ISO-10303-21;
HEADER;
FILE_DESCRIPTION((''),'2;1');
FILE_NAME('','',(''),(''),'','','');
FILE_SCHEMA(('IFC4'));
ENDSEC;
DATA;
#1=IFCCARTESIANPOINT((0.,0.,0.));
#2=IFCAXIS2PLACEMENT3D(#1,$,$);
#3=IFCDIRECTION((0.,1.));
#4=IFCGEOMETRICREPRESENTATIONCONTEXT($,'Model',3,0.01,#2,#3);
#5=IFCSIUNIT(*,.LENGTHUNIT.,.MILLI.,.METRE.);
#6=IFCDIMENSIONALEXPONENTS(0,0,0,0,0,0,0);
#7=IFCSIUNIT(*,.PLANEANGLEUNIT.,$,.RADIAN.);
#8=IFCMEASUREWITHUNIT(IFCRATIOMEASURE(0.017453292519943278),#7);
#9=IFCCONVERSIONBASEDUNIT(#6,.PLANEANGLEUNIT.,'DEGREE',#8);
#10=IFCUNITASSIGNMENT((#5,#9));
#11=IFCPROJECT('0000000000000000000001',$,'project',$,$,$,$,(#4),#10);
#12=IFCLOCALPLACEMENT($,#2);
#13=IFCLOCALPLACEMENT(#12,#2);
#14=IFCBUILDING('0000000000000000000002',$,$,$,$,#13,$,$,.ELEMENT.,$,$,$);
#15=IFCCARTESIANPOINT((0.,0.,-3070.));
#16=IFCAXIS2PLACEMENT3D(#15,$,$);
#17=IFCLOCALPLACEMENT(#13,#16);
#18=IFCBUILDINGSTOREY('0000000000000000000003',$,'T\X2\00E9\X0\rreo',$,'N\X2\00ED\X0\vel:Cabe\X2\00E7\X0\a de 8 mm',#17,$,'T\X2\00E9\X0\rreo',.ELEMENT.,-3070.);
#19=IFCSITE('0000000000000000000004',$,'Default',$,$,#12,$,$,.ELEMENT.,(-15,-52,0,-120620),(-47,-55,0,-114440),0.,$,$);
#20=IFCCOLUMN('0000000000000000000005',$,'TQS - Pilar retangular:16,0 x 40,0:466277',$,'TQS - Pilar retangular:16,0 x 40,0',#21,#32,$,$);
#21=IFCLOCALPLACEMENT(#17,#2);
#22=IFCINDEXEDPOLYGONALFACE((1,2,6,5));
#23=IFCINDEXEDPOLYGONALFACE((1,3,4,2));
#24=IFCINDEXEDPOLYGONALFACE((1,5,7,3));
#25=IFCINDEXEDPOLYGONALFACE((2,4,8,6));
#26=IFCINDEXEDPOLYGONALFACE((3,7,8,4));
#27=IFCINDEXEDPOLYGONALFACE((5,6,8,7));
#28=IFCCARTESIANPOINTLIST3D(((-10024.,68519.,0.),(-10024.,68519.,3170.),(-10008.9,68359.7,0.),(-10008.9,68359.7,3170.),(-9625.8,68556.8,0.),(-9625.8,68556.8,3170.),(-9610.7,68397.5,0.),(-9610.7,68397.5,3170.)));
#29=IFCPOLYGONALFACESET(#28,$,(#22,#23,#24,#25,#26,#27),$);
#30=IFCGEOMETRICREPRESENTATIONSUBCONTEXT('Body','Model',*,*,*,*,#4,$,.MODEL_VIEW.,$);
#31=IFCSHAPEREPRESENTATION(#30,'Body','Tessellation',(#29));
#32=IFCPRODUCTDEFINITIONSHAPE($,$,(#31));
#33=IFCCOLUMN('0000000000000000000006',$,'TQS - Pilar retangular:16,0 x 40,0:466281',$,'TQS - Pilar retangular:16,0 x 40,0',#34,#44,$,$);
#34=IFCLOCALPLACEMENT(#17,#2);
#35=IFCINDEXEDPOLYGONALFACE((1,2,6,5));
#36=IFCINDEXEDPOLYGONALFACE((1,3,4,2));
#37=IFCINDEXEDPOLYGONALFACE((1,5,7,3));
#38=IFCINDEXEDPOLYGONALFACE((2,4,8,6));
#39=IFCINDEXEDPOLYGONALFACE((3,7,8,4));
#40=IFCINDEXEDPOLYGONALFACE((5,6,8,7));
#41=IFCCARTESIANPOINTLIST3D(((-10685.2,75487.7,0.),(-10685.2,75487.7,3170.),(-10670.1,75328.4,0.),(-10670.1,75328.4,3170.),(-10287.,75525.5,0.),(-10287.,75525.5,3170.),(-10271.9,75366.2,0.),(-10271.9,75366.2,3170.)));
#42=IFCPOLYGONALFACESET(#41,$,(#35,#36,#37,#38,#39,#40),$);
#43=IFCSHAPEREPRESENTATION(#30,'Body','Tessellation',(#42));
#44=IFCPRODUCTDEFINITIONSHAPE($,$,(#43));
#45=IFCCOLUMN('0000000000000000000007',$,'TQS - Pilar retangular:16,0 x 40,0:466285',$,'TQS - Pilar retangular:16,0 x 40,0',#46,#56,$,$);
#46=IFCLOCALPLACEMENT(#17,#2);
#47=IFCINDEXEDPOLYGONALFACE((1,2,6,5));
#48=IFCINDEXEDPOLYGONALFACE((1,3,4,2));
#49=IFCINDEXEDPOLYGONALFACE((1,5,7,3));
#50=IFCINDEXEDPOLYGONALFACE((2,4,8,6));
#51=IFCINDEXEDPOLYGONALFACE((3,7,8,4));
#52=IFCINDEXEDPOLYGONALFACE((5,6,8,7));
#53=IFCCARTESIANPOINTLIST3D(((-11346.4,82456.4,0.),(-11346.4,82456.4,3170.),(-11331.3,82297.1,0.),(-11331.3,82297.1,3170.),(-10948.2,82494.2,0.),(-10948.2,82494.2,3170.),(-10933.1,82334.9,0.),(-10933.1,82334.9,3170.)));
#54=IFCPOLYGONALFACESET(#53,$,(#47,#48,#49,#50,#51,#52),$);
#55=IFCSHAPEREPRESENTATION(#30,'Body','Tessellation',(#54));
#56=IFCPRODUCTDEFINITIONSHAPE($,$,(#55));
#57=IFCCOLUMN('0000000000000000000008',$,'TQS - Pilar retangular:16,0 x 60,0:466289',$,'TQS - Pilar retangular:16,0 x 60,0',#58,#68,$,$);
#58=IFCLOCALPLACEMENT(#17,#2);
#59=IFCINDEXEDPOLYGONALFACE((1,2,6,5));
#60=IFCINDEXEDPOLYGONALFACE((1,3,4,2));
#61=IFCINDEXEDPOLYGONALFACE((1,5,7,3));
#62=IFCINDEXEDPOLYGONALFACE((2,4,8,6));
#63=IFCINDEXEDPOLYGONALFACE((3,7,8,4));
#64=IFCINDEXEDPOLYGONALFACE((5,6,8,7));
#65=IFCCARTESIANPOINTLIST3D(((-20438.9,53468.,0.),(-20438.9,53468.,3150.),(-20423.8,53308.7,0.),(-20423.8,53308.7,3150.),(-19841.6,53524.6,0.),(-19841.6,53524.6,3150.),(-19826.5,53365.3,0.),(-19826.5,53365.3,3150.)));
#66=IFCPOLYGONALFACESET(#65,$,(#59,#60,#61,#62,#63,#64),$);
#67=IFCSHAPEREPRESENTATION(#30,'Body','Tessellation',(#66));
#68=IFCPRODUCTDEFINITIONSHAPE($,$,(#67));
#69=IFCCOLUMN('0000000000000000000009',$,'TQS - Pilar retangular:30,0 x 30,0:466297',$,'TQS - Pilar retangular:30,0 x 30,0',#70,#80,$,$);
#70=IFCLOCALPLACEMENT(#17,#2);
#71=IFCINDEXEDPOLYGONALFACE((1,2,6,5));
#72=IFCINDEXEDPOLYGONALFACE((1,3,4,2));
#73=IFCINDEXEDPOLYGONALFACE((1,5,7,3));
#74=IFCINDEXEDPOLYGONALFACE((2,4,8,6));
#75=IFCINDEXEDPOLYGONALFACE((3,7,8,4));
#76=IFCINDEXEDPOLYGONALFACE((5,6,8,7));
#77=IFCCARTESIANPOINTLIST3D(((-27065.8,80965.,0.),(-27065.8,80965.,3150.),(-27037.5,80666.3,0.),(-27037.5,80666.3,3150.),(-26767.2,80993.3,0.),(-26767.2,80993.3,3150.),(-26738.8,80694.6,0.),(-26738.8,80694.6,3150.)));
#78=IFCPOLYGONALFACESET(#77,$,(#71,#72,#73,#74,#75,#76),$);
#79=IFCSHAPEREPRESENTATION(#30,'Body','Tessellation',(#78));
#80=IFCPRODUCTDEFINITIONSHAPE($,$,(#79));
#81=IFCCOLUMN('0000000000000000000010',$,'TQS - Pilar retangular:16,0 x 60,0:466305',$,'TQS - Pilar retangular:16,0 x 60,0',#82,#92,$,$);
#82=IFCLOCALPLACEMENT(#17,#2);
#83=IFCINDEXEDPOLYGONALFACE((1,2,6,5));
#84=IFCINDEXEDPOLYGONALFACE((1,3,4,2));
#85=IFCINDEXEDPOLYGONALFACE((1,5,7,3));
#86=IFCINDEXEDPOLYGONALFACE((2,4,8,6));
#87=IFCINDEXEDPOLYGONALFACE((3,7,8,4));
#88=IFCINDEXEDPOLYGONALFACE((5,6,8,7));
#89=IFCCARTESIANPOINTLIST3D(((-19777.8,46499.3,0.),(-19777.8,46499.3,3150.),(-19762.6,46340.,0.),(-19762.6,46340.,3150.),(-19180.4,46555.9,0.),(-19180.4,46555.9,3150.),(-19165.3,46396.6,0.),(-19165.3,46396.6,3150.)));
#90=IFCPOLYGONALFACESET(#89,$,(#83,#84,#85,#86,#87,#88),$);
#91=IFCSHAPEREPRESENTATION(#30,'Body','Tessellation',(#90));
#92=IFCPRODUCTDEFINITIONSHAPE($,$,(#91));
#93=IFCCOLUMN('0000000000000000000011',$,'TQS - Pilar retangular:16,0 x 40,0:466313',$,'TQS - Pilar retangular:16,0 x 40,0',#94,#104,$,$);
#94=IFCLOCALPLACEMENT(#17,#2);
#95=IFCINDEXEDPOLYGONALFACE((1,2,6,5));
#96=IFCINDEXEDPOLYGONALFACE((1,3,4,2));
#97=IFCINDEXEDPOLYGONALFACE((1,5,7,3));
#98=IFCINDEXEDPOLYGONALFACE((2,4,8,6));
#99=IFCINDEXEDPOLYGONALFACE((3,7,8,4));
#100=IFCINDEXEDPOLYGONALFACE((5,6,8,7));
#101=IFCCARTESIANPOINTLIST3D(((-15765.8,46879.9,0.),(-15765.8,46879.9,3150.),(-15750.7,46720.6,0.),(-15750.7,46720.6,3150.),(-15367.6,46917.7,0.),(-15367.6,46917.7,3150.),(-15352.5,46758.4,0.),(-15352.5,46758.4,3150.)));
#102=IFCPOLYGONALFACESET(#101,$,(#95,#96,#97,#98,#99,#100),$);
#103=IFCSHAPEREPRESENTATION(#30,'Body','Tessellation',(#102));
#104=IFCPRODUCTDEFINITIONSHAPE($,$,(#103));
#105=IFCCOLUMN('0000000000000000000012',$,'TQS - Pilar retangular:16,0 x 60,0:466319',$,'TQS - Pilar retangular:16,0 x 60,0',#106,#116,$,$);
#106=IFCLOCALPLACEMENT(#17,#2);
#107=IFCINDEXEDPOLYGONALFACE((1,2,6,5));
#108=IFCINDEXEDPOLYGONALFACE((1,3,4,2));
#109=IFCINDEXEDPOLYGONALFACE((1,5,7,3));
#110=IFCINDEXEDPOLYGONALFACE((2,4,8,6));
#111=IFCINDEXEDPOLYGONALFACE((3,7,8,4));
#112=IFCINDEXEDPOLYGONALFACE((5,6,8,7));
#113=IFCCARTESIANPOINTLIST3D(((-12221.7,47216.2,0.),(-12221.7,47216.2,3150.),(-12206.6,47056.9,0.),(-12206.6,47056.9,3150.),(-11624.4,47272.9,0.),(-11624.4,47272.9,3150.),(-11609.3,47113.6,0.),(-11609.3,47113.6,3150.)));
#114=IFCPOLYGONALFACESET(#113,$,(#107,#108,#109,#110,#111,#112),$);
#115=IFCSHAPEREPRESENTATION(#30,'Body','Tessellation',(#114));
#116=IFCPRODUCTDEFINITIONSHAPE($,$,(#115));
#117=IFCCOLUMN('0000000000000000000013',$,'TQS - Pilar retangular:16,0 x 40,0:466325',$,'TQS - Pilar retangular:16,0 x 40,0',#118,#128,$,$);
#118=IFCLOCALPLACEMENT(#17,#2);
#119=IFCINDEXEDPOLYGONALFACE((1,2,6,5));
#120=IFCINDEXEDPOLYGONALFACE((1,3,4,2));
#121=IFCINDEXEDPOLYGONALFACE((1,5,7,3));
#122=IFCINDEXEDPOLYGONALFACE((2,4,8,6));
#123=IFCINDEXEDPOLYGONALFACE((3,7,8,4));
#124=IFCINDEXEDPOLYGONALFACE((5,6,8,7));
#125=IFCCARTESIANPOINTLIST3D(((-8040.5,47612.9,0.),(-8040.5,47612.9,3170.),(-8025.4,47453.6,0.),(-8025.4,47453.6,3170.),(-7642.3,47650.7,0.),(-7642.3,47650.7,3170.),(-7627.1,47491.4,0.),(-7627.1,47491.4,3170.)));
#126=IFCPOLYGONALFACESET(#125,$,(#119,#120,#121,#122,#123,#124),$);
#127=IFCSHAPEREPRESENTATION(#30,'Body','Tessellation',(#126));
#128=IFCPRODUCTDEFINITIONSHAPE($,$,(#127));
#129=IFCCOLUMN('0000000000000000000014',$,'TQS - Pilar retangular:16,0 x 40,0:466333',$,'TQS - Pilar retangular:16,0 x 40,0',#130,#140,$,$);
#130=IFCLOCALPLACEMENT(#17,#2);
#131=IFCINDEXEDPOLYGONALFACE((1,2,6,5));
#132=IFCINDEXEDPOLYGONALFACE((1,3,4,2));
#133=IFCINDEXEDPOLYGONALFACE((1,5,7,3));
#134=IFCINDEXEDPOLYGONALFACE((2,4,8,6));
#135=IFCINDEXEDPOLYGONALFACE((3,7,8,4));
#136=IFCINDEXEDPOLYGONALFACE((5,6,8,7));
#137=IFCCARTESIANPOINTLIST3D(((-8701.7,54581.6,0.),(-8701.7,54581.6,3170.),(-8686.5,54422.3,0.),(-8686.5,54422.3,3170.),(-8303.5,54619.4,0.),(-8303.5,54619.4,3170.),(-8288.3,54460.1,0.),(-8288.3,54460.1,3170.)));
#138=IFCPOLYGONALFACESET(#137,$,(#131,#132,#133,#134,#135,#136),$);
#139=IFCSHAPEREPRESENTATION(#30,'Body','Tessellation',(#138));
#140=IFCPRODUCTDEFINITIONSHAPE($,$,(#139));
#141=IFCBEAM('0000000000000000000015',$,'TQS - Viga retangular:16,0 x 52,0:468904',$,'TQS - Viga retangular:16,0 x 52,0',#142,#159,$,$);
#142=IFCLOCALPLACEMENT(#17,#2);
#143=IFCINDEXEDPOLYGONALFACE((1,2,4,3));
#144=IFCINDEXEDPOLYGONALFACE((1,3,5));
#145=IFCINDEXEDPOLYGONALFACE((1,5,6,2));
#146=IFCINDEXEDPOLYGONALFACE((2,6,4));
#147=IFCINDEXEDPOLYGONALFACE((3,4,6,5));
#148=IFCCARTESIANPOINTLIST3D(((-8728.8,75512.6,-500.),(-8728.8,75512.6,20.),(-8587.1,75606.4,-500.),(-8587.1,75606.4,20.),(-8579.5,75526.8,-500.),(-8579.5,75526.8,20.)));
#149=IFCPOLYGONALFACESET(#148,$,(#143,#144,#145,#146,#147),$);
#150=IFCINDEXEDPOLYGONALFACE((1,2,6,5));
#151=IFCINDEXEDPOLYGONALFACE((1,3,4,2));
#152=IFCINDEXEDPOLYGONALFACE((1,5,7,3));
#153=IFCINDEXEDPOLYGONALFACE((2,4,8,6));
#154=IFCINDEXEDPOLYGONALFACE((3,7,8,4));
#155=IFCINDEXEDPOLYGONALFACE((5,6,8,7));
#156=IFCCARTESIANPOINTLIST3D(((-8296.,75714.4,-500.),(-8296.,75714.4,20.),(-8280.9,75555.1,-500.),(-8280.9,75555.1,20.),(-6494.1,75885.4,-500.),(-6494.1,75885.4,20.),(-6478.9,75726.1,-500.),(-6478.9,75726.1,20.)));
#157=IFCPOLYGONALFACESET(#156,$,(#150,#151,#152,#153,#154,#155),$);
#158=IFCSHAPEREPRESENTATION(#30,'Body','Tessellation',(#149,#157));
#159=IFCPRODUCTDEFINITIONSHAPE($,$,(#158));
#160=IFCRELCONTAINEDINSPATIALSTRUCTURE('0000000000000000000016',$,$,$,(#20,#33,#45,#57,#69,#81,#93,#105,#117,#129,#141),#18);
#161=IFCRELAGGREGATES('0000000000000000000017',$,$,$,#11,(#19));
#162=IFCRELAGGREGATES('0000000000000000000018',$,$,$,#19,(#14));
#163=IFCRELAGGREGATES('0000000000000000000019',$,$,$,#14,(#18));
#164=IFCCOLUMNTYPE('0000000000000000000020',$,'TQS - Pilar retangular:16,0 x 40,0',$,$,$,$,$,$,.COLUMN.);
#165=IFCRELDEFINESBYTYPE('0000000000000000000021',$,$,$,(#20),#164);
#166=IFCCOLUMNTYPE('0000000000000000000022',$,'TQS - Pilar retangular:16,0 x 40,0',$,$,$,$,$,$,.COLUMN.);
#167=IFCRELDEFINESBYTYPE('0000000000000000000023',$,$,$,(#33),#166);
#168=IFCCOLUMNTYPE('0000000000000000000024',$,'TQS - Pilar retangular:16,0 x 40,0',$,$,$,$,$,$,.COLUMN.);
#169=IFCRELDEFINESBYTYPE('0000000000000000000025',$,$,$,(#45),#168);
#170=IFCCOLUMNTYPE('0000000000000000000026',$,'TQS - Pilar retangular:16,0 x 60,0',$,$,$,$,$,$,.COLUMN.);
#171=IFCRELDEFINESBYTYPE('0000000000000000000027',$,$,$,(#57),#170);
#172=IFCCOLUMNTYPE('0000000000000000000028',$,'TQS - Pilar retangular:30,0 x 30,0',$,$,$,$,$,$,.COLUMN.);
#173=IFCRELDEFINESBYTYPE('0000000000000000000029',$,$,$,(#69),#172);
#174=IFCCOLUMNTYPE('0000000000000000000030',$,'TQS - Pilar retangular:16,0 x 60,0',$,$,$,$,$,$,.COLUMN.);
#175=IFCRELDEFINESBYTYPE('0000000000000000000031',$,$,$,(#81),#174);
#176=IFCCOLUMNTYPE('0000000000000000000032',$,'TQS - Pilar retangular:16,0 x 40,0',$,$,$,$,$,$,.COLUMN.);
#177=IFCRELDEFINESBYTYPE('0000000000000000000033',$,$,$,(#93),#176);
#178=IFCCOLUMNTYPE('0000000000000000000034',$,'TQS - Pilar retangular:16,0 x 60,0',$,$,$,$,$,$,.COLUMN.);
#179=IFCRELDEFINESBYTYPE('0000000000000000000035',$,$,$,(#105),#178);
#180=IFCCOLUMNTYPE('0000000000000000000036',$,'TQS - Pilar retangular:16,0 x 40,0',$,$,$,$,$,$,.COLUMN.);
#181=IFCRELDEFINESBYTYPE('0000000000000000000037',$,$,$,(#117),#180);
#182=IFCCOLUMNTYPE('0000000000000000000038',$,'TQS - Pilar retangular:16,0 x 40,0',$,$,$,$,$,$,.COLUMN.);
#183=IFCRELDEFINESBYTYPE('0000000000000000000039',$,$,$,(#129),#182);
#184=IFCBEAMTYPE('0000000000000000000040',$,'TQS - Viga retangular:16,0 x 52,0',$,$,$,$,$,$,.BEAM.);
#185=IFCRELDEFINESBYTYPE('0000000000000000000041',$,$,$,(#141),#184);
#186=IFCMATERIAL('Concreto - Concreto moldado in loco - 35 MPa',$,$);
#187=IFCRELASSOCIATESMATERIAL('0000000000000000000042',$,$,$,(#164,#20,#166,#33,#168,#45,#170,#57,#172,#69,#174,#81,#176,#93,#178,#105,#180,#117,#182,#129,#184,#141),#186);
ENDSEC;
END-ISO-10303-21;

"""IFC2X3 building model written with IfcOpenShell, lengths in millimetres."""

from ifc_helpers import new_model, entity, si_unit, converted_unit, direction, frame, frame_2d, origin, origin_2d_with_axis, place, context, subcontext, project, spatial, rectangle, extrude, clip, halfspace, source, transform, mapped, material, type_object, type_shapes, element, save


model = new_model("IFC2X3")

# Units and contexts
model_context = context("Model", 3, precision=0.01, world=origin(), true_north=direction((0.0, 1.0)))
body_context = subcontext(model_context, "Body", "Model", "MODEL_VIEW")
ifc_project = project(units=[si_unit("LENGTHUNIT", "METRE", prefix="MILLI"), converted_unit("PLANEANGLEUNIT", "DEGREE", entity("IfcRatioMeasure", 0.017453292519943278), si_unit("PLANEANGLEUNIT", "RADIAN"), dimensions=[0, 0, 0, 0, 0, 0, 0])], contexts=[model_context])

# Site, building, storey
site_placement = place(None, origin())
site = spatial("IfcSite", under=ifc_project, at=site_placement, Name="Default", CompositionType="ELEMENT", RefLatitude=(-15, -52, 0, -120620), RefLongitude=(-47, -55, 0, -114440), RefElevation=0.0)
building_placement = place(site_placement, origin())
building = spatial("IfcBuilding", under=site, at=building_placement, CompositionType="ELEMENT")
storey_placement = place(building_placement, frame((0.0, 0.0, -3070.0)))
storey = spatial("IfcBuildingStorey", under=building, at=storey_placement, Name="Térreo", ObjectType="Nível:Cabeça de 8 mm", LongName="Térreo", CompositionType="ELEMENT", Elevation=-3070.0)

# Columns
ifc_material = material(Name="Concreto - Concreto moldado in loco - 35 MPa")
column_type_1 = type_object("IfcColumnType", Name="TQS - Pilar retangular:16,0 x 40,0", PredefinedType="COLUMN", material=ifc_material)
shared_shape_1 = source(origin(), body_context, "Body", "SweptSolid", [
    extrude(rectangle(XDim=400.0, YDim=160.0, at=frame_2d((0.0, 0.0), x_axis=(1.0, 0.0))), frame((-9817.4, 68458.3, -3070.0), z_axis=(0.0, 0.0, 1.0), x_axis=(-0.995529, -0.094456, 0.0)), (0.0, 0.0, 1.0), 3170.0),
])
type_shapes(column_type_1, [shared_shape_1])
column_1_placement = place(storey_placement, frame((0.0, 0.0, 3070.0)))
element("IfcColumn", 1, at=column_1_placement, inside=storey, type_object=column_type_1, material=ifc_material, Name="TQS - Pilar retangular:16,0 x 40,0:466277", ObjectType="TQS - Pilar retangular:16,0 x 40,0", context=body_context, shape_type="MappedRepresentation", body=[
    mapped(shared_shape_1, transform((0.0, 0.0, 0.0), scale=1.0)),
])
column_type_2 = type_object("IfcColumnType", Name="TQS - Pilar retangular:16,0 x 40,0", PredefinedType="COLUMN", material=ifc_material)
shared_shape_2 = source(origin(), body_context, "Body", "SweptSolid", [
    extrude(rectangle(XDim=400.0, YDim=160.0, at=origin_2d_with_axis()), frame((-10478.6, 75427.0, -3070.0), z_axis=(0.0, 0.0, 1.0), x_axis=(-0.995529, -0.094456, 0.0)), (0.0, 0.0, 1.0), 3170.0),
])
type_shapes(column_type_2, [shared_shape_2])
column_2_placement = place(storey_placement, frame((0.0, 0.0, 3070.0)))
element("IfcColumn", 2, at=column_2_placement, inside=storey, type_object=column_type_2, material=ifc_material, Name="TQS - Pilar retangular:16,0 x 40,0:466281", ObjectType="TQS - Pilar retangular:16,0 x 40,0", context=body_context, shape_type="MappedRepresentation", body=[
    mapped(shared_shape_2, transform((0.0, 0.0, 0.0), scale=1.0)),
])
column_type_3 = type_object("IfcColumnType", Name="TQS - Pilar retangular:16,0 x 40,0", PredefinedType="COLUMN", material=ifc_material)
shared_shape_3 = source(origin(), body_context, "Body", "SweptSolid", [
    extrude(rectangle(XDim=400.0, YDim=160.0, at=origin_2d_with_axis()), frame((-11139.8, 82395.7, -3070.0), z_axis=(0.0, 0.0, 1.0), x_axis=(-0.995529, -0.094456, 0.0)), (0.0, 0.0, 1.0), 3170.0),
])
type_shapes(column_type_3, [shared_shape_3])
column_3_placement = place(storey_placement, frame((0.0, 0.0, 3070.0)))
element("IfcColumn", 3, at=column_3_placement, inside=storey, type_object=column_type_3, material=ifc_material, Name="TQS - Pilar retangular:16,0 x 40,0:466285", ObjectType="TQS - Pilar retangular:16,0 x 40,0", context=body_context, shape_type="MappedRepresentation", body=[
    mapped(shared_shape_3, transform((0.0, 0.0, 0.0), scale=1.0)),
])
column_type_4 = type_object("IfcColumnType", Name="TQS - Pilar retangular:16,0 x 60,0", PredefinedType="COLUMN", material=ifc_material)
shared_shape_4 = source(origin(), body_context, "Body", "SweptSolid", [
    extrude(rectangle(XDim=600.0, YDim=160.0, at=origin_2d_with_axis()), frame((-20132.7, 53416.7, -3070.0), z_axis=(0.0, 0.0, 1.0), x_axis=(-0.995529, -0.094456, 0.0)), (0.0, 0.0, 1.0), 3150.0),
])
type_shapes(column_type_4, [shared_shape_4])
column_4_placement = place(storey_placement, frame((0.0, 0.0, 3070.0)))
element("IfcColumn", 4, at=column_4_placement, inside=storey, type_object=column_type_4, material=ifc_material, Name="TQS - Pilar retangular:16,0 x 60,0:466289", ObjectType="TQS - Pilar retangular:16,0 x 60,0", context=body_context, shape_type="MappedRepresentation", body=[
    mapped(shared_shape_4, transform((0.0, 0.0, 0.0), scale=1.0)),
])
column_type_5 = type_object("IfcColumnType", Name="TQS - Pilar retangular:30,0 x 30,0", PredefinedType="COLUMN", material=ifc_material)
shared_shape_5 = source(origin(), body_context, "Body", "SweptSolid", [
    extrude(rectangle(XDim=300.0, YDim=300.0, at=origin_2d_with_axis()), frame((-26902.3, 80829.8, -3070.0), z_axis=(0.0, 0.0, 1.0), x_axis=(-0.995529, -0.094456, 0.0)), (0.0, 0.0, 1.0), 3150.0),
])
type_shapes(column_type_5, [shared_shape_5])
column_5_placement = place(storey_placement, frame((0.0, 0.0, 3070.0)))
element("IfcColumn", 5, at=column_5_placement, inside=storey, type_object=column_type_5, material=ifc_material, Name="TQS - Pilar retangular:30,0 x 30,0:466297", ObjectType="TQS - Pilar retangular:30,0 x 30,0", context=body_context, shape_type="MappedRepresentation", body=[
    mapped(shared_shape_5, transform((0.0, 0.0, 0.0), scale=1.0)),
])
column_type_6 = type_object("IfcColumnType", Name="TQS - Pilar retangular:16,0 x 60,0", PredefinedType="COLUMN", material=ifc_material)
shared_shape_6 = source(origin(), body_context, "Body", "SweptSolid", [
    extrude(rectangle(XDim=600.0, YDim=160.0, at=origin_2d_with_axis()), frame((-19471.5, 46448.0, -3070.0), z_axis=(0.0, 0.0, 1.0), x_axis=(-0.995529, -0.094456, 0.0)), (0.0, 0.0, 1.0), 3150.0),
])
type_shapes(column_type_6, [shared_shape_6])
column_6_placement = place(storey_placement, frame((0.0, 0.0, 3070.0)))
element("IfcColumn", 6, at=column_6_placement, inside=storey, type_object=column_type_6, material=ifc_material, Name="TQS - Pilar retangular:16,0 x 60,0:466305", ObjectType="TQS - Pilar retangular:16,0 x 60,0", context=body_context, shape_type="MappedRepresentation", body=[
    mapped(shared_shape_6, transform((0.0, 0.0, 0.0), scale=1.0)),
])
column_type_7 = type_object("IfcColumnType", Name="TQS - Pilar retangular:16,0 x 40,0", PredefinedType="COLUMN", material=ifc_material)
shared_shape_7 = source(origin(), body_context, "Body", "SweptSolid", [
    extrude(rectangle(XDim=400.0, YDim=160.0, at=frame_2d((0.0, 0.0), x_axis=(1.0, 0.0))), frame((-15559.1, 46819.2, -3070.0), z_axis=(0.0, 0.0, 1.0), x_axis=(-0.995529, -0.094456, 0.0)), (0.0, 0.0, 1.0), 3150.0),
])
type_shapes(column_type_7, [shared_shape_7])
column_7_placement = place(storey_placement, frame((0.0, 0.0, 3070.0)))
element("IfcColumn", 7, at=column_7_placement, inside=storey, type_object=column_type_7, material=ifc_material, Name="TQS - Pilar retangular:16,0 x 40,0:466313", ObjectType="TQS - Pilar retangular:16,0 x 40,0", context=body_context, shape_type="MappedRepresentation", body=[
    mapped(shared_shape_7, transform((0.0, 0.0, 0.0), scale=1.0)),
])
column_type_8 = type_object("IfcColumnType", Name="TQS - Pilar retangular:16,0 x 60,0", PredefinedType="COLUMN", material=ifc_material)
shared_shape_8 = source(origin(), body_context, "Body", "SweptSolid", [
    extrude(rectangle(XDim=600.0, YDim=160.0, at=frame_2d((0.0, 0.0), x_axis=(1.0, 0.0))), frame((-11915.5, 47164.9, -3070.0), z_axis=(0.0, 0.0, 1.0), x_axis=(-0.995529, -0.094456, 0.0)), (0.0, 0.0, 1.0), 3150.0),
])
type_shapes(column_type_8, [shared_shape_8])
column_8_placement = place(storey_placement, frame((0.0, 0.0, 3070.0)))
element("IfcColumn", 8, at=column_8_placement, inside=storey, type_object=column_type_8, material=ifc_material, Name="TQS - Pilar retangular:16,0 x 60,0:466319", ObjectType="TQS - Pilar retangular:16,0 x 60,0", context=body_context, shape_type="MappedRepresentation", body=[
    mapped(shared_shape_8, transform((0.0, 0.0, 0.0), scale=1.0)),
])
column_type_9 = type_object("IfcColumnType", Name="TQS - Pilar retangular:16,0 x 40,0", PredefinedType="COLUMN", material=ifc_material)
shared_shape_9 = source(origin(), body_context, "Body", "SweptSolid", [
    extrude(rectangle(XDim=400.0, YDim=160.0, at=origin_2d_with_axis()), frame((-7833.8, 47552.1, -3070.0), z_axis=(0.0, 0.0, 1.0), x_axis=(-0.995529, -0.094456, 0.0)), (0.0, 0.0, 1.0), 3170.0),
])
type_shapes(column_type_9, [shared_shape_9])
column_9_placement = place(storey_placement, frame((0.0, 0.0, 3070.0)))
element("IfcColumn", 9, at=column_9_placement, inside=storey, type_object=column_type_9, material=ifc_material, Name="TQS - Pilar retangular:16,0 x 40,0:466325", ObjectType="TQS - Pilar retangular:16,0 x 40,0", context=body_context, shape_type="MappedRepresentation", body=[
    mapped(shared_shape_9, transform((0.0, 0.0, 0.0), scale=1.0)),
])
column_type_10 = type_object("IfcColumnType", Name="TQS - Pilar retangular:16,0 x 40,0", PredefinedType="COLUMN", material=ifc_material)
shared_shape_10 = source(origin(), body_context, "Body", "SweptSolid", [
    extrude(rectangle(XDim=400.0, YDim=160.0, at=origin_2d_with_axis()), frame((-8495.0, 54520.8, -3070.0), z_axis=(0.0, 0.0, 1.0), x_axis=(-0.995529, -0.094456, 0.0)), (0.0, 0.0, 1.0), 3170.0),
])
type_shapes(column_type_10, [shared_shape_10])
column_10_placement = place(storey_placement, frame((0.0, 0.0, 3070.0)))
element("IfcColumn", 10, at=column_10_placement, inside=storey, type_object=column_type_10, material=ifc_material, Name="TQS - Pilar retangular:16,0 x 40,0:466333", ObjectType="TQS - Pilar retangular:16,0 x 40,0", context=body_context, shape_type="MappedRepresentation", body=[
    mapped(shared_shape_10, transform((0.0, 0.0, 0.0), scale=1.0)),
])

# Beam
beam_type_1 = type_object("IfcBeamType", Name="TQS - Viga retangular:16,0 x 52,0", PredefinedType="BEAM", material=ifc_material)
shared_shape_11 = source(origin(), body_context, "Body", "SweptSolid", [
    clip(extrude(rectangle(XDim=520.0, YDim=80.0, at=frame_2d((0.0, 0.0), x_axis=(0.0, 1.0))), frame((-8583.3, 75566.6, -3310.0), z_axis=(-0.995529, -0.094456, 0.0), x_axis=(0.094456, -0.995529, 0.0)), (0.0, 0.0, 1.0), 150.0), halfspace(frame((-8445.3, 75700.2, -3050.0), z_axis=(-0.551828, 0.833958, 0.0), x_axis=(0.833958, 0.551828, 0.0)), False)),
    extrude(rectangle(XDim=520.0, YDim=160.0, at=frame_2d((0.0, 0.0), x_axis=(1.0, 0.0))), frame((-6486.5, 75805.7, -3310.0), z_axis=(-0.995529, -0.094456, 0.0), x_axis=(0.0, 0.0, -1.0)), (0.0, 0.0, 1.0), 1810.0),
])
type_shapes(beam_type_1, [shared_shape_11])
beam_1_placement = place(storey_placement, frame((0.0, 0.0, 3070.0)))
element("IfcBeam", 11, at=beam_1_placement, inside=storey, type_object=beam_type_1, material=ifc_material, Name="TQS - Viga retangular:16,0 x 52,0:468904", ObjectType="TQS - Viga retangular:16,0 x 52,0", context=body_context, shape_type="MappedRepresentation", body=[
    mapped(shared_shape_11, transform((0.0, 0.0, 0.0), scale=1.0)),
])

save(model, "model.ifc")
